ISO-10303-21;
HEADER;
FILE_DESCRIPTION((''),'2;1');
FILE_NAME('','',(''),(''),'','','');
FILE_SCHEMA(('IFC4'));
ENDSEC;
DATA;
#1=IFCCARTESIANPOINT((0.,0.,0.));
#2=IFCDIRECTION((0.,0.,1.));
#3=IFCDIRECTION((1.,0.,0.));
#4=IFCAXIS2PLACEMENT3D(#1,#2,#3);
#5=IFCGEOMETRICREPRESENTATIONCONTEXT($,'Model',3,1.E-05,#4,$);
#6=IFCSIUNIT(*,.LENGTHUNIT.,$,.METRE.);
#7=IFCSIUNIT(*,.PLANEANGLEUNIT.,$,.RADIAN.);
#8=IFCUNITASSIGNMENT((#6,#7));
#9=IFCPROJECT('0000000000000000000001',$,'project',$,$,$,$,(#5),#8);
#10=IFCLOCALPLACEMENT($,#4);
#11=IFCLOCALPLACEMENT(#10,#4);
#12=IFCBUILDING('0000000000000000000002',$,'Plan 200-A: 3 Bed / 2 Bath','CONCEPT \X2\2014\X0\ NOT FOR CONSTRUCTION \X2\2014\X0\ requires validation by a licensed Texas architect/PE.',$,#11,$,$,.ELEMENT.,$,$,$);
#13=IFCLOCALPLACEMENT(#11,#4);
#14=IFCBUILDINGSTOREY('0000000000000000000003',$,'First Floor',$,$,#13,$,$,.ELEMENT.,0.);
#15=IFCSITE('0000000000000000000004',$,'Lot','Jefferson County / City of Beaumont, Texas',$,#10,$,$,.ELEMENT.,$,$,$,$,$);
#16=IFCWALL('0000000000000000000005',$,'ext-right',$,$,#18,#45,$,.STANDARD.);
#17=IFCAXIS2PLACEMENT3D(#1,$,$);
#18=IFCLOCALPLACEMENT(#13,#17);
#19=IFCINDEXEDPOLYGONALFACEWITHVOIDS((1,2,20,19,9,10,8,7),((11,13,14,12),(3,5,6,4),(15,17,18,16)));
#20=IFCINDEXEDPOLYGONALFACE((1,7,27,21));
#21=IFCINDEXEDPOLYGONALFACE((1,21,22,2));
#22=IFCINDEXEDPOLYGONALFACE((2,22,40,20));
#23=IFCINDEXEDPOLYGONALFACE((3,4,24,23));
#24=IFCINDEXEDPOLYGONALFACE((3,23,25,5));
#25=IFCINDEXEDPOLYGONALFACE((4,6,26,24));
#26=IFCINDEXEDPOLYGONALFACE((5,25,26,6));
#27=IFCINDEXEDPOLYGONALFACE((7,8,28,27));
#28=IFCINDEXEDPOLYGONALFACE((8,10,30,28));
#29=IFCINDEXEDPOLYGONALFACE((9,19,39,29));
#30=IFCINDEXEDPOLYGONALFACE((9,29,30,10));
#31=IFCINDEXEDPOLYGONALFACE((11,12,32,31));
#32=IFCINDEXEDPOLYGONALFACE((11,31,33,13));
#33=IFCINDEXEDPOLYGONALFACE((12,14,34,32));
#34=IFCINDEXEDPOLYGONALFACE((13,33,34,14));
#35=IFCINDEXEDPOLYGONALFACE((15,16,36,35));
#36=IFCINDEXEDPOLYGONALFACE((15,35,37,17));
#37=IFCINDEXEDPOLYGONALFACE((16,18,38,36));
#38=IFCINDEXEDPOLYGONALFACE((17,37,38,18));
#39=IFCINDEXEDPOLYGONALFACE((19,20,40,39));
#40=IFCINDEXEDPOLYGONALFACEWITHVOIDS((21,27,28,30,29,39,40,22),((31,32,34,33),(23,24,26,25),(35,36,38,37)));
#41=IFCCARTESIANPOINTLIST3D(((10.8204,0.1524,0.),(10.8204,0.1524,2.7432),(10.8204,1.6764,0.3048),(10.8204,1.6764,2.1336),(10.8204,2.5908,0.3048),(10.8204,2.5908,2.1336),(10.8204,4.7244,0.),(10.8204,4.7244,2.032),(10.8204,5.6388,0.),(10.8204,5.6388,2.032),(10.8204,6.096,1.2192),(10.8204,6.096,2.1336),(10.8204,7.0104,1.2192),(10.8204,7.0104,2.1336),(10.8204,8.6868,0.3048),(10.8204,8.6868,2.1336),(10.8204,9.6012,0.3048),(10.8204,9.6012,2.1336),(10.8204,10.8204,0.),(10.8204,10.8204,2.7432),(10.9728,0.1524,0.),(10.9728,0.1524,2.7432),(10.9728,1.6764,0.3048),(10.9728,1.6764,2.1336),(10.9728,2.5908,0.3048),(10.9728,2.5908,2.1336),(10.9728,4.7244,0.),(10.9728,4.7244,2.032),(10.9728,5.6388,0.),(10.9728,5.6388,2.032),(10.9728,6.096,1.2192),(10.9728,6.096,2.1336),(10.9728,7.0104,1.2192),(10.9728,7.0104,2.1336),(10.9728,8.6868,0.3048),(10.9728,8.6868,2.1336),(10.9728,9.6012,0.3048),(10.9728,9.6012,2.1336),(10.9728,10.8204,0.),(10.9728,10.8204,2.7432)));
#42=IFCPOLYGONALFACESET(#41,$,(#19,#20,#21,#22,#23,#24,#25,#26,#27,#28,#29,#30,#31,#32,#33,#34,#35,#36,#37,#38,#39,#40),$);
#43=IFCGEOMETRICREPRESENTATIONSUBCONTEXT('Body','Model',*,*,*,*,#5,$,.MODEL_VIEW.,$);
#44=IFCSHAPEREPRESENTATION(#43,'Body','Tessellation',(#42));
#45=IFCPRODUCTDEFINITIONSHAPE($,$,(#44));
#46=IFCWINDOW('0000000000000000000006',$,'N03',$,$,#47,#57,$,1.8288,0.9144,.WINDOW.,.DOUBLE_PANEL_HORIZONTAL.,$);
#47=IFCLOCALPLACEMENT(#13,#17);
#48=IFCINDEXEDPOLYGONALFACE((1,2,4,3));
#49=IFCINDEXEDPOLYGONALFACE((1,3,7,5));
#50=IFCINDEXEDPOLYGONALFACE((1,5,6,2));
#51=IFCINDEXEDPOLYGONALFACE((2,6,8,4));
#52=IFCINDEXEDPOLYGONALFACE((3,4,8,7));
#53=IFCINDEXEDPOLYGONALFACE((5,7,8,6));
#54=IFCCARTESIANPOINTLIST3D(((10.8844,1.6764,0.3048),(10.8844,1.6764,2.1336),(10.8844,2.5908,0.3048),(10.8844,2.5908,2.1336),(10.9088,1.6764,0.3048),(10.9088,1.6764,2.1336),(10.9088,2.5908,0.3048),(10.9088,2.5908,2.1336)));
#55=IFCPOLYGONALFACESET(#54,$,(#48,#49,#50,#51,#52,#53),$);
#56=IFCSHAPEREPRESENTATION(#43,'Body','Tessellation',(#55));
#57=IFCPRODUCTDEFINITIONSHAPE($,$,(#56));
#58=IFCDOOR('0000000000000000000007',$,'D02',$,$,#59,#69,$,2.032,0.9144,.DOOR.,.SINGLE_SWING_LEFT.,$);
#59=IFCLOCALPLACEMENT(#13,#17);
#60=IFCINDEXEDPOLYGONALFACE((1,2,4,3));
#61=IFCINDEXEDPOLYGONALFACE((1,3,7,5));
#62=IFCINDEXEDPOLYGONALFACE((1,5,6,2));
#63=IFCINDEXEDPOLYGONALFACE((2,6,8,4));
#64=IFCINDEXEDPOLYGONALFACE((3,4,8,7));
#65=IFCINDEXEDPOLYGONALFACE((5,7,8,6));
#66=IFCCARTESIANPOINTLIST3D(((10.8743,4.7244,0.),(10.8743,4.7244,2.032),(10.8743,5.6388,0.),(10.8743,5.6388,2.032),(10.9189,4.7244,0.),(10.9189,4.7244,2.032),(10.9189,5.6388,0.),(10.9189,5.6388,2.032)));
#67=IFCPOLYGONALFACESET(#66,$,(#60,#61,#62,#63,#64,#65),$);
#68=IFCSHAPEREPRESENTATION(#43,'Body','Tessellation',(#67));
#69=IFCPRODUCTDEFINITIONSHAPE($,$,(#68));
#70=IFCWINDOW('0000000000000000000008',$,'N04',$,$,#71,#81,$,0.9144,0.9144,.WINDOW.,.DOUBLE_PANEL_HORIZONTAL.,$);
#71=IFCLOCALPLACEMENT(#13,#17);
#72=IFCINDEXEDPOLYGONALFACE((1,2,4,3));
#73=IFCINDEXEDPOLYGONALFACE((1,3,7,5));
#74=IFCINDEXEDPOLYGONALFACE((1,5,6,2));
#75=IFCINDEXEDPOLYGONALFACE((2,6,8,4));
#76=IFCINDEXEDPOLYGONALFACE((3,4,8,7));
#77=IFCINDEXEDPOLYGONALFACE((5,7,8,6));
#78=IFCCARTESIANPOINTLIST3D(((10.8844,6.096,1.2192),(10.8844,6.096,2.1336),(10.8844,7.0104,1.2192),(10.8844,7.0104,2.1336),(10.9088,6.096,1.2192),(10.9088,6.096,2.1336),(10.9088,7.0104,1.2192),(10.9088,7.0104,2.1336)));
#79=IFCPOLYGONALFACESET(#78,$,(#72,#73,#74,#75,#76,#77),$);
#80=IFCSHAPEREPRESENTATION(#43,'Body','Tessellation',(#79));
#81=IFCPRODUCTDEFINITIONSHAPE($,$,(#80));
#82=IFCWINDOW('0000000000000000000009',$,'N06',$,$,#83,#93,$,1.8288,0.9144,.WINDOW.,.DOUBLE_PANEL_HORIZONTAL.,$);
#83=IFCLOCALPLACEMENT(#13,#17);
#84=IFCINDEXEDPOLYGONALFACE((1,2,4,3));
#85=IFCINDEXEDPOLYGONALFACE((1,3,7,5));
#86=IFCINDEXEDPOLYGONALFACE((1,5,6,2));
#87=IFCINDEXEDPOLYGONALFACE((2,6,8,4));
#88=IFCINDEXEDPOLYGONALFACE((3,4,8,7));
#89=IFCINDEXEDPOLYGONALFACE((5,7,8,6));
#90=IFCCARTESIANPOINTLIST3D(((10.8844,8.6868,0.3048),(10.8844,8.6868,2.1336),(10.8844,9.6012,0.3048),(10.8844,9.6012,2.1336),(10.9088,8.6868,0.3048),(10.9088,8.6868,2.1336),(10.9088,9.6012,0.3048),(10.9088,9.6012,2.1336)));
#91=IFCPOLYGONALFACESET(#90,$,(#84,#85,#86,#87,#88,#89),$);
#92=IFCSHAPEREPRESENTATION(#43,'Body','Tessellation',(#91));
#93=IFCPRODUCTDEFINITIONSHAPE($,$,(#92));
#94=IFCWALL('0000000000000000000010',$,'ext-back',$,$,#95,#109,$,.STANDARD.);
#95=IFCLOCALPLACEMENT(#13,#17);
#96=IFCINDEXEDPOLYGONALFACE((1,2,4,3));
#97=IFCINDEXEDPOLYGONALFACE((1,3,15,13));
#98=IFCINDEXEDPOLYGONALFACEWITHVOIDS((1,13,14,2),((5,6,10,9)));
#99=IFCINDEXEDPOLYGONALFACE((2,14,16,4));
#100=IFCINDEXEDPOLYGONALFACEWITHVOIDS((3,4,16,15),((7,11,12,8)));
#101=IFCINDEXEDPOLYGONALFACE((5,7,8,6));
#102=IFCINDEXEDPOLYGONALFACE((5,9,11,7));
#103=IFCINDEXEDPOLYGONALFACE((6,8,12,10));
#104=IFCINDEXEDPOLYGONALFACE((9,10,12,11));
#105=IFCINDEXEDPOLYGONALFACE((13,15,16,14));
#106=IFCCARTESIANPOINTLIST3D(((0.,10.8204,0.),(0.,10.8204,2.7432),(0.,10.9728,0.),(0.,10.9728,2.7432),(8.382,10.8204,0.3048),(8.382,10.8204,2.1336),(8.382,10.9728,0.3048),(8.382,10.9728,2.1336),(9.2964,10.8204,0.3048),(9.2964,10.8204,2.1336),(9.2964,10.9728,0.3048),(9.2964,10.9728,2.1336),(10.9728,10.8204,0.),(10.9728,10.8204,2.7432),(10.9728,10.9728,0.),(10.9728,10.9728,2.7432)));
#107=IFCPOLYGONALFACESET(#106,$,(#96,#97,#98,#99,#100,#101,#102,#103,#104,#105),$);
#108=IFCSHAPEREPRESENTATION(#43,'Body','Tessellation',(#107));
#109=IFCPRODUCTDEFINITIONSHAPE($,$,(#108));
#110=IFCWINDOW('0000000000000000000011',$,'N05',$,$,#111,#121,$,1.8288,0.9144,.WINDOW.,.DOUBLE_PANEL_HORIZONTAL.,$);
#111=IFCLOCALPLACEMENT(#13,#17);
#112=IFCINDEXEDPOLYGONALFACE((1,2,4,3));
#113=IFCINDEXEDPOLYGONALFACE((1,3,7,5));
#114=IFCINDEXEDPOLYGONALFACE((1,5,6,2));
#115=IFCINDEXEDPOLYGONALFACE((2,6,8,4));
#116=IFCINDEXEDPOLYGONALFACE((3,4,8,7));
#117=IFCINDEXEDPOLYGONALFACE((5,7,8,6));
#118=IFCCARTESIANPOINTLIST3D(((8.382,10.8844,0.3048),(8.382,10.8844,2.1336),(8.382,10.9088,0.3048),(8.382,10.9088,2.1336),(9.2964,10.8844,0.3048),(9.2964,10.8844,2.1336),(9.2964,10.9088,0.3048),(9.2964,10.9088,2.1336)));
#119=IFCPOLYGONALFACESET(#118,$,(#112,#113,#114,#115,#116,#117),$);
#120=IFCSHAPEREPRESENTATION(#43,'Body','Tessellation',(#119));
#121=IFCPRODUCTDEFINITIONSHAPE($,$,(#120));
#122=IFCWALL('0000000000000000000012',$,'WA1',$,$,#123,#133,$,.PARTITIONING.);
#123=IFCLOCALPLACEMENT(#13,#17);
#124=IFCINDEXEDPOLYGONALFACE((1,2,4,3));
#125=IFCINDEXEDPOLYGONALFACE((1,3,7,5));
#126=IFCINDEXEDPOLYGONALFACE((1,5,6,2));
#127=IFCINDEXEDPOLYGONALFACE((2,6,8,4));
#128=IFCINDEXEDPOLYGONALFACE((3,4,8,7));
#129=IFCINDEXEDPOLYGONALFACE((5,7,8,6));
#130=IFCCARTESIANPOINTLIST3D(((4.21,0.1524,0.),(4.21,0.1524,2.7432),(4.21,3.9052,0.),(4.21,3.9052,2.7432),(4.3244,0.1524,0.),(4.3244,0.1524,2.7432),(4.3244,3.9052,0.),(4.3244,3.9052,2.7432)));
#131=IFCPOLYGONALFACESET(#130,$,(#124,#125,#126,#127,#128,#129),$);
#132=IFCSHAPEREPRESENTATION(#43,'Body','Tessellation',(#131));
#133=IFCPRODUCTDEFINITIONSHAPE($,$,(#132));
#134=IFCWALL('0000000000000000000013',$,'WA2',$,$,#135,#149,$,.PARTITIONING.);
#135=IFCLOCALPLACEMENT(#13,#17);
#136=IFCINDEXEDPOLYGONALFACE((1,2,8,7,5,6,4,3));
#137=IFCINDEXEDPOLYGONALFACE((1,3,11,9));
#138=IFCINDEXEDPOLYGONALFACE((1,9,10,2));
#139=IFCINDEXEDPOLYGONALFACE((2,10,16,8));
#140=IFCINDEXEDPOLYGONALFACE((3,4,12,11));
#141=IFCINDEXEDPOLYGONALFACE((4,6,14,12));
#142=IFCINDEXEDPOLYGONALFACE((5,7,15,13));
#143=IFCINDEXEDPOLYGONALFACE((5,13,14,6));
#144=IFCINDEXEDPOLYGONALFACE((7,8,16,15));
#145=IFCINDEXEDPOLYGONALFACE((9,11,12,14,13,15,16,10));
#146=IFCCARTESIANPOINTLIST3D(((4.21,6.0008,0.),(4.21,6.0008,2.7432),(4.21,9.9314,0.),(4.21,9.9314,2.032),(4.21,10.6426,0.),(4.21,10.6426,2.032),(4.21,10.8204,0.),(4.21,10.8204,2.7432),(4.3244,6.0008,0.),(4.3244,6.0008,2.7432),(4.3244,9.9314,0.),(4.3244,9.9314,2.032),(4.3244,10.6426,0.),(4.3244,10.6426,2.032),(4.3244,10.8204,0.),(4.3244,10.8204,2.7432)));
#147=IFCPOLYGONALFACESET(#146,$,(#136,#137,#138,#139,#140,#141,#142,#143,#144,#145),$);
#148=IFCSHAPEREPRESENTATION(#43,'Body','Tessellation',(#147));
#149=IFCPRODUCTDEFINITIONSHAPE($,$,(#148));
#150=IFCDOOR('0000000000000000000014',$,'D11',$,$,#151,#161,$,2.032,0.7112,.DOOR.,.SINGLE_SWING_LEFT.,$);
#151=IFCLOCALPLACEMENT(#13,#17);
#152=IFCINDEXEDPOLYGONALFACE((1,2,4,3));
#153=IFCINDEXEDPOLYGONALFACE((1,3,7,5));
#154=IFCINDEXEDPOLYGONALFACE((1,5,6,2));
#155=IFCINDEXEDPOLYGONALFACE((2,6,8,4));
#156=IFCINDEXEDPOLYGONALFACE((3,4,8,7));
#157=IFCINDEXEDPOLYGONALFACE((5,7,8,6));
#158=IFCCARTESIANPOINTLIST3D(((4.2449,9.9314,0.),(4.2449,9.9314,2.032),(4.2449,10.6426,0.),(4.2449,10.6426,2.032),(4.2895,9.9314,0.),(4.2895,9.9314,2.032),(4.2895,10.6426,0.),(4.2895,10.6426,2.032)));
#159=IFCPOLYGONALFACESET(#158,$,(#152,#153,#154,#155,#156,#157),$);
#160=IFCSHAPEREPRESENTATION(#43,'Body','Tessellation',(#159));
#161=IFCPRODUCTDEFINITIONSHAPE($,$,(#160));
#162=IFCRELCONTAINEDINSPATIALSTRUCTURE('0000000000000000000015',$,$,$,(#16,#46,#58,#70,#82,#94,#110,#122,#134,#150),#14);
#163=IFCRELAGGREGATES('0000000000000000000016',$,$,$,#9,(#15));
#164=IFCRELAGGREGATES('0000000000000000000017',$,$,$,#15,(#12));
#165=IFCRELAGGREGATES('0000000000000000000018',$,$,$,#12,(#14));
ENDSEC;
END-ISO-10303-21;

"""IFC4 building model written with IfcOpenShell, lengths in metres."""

from ifc_helpers import new_model, si_unit, frame, frame_2d, origin_with_axes, place, context, subcontext, project, spatial, rectangle, extrude, element, fill, save


model = new_model("IFC4")

# Units and contexts
model_context = context("Model", 3, precision=1e-05, world=origin_with_axes())
body_context = subcontext(model_context, "Body", "Model", "MODEL_VIEW")
ifc_project = project(units=[si_unit("LENGTHUNIT", "METRE"), si_unit("PLANEANGLEUNIT", "RADIAN")], contexts=[model_context])

# Site, building, storey
site_placement = place(None, origin_with_axes())
site = spatial("IfcSite", under=ifc_project, at=site_placement, Name="Lot", Description="Jefferson County / City of Beaumont, Texas", CompositionType="ELEMENT")
building_placement = place(site_placement, origin_with_axes())
building = spatial("IfcBuilding", under=site, at=building_placement, Name="Plan 200-A: 3 Bed / 2 Bath", Description="CONCEPT — NOT FOR CONSTRUCTION — requires validation by a licensed Texas architect/PE.", CompositionType="ELEMENT")
storey_placement = place(building_placement, origin_with_axes())
storey = spatial("IfcBuildingStorey", under=building, at=storey_placement, Name="First Floor", CompositionType="ELEMENT", Elevation=0.0)

# Wall, openings, windows, door
wall_1_placement = place(storey_placement, frame((10.8966, 0.1524, 0.0), z_axis=(0.0, 0.0, 1.0), x_axis=(0.0, 1.0, 0.0)))
wall_1 = element("IfcWall", 1, at=wall_1_placement, inside=storey, Name="ext-right", PredefinedType="STANDARD", context=body_context, shape_type="SweptSolid", body=[
    extrude(rectangle(XDim=10.668, YDim=0.1524, at=frame_2d((5.334, 0.0), x_axis=(1.0, 0.0))), origin_with_axes(), (0.0, 0.0, 1.0), 2.7432),
])
opening_1_placement = place(wall_1_placement, frame((1.524, 0.0, 0.3048), z_axis=(0.0, 0.0, 1.0), x_axis=(1.0, 0.0, 0.0)))
opening_1 = element("IfcOpeningElement", 2, at=opening_1_placement, cuts=wall_1, PredefinedType="OPENING", context=body_context, shape_type="SweptSolid", body=[
    extrude(rectangle(XDim=0.9144, YDim=0.1829, at=frame_2d((0.4572, 0.0), x_axis=(1.0, 0.0))), origin_with_axes(), (0.0, 0.0, 1.0), 1.8288),
])
opening_2_placement = place(wall_1_placement, frame((4.572, 0.0, 0.0), z_axis=(0.0, 0.0, 1.0), x_axis=(1.0, 0.0, 0.0)))
opening_2 = element("IfcOpeningElement", 3, at=opening_2_placement, cuts=wall_1, PredefinedType="OPENING", context=body_context, shape_type="SweptSolid", body=[
    extrude(rectangle(XDim=0.9144, YDim=0.1829, at=frame_2d((0.4572, 0.0), x_axis=(1.0, 0.0))), origin_with_axes(), (0.0, 0.0, 1.0), 2.032),
])
opening_3_placement = place(wall_1_placement, frame((5.9436, 0.0, 1.2192), z_axis=(0.0, 0.0, 1.0), x_axis=(1.0, 0.0, 0.0)))
opening_3 = element("IfcOpeningElement", 4, at=opening_3_placement, cuts=wall_1, PredefinedType="OPENING", context=body_context, shape_type="SweptSolid", body=[
    extrude(rectangle(XDim=0.9144, YDim=0.1829, at=frame_2d((0.4572, 0.0), x_axis=(1.0, 0.0))), origin_with_axes(), (0.0, 0.0, 1.0), 0.9144),
])
opening_4_placement = place(wall_1_placement, frame((8.5344, 0.0, 0.3048), z_axis=(0.0, 0.0, 1.0), x_axis=(1.0, 0.0, 0.0)))
opening_4 = element("IfcOpeningElement", 5, at=opening_4_placement, cuts=wall_1, PredefinedType="OPENING", context=body_context, shape_type="SweptSolid", body=[
    extrude(rectangle(XDim=0.9144, YDim=0.1829, at=frame_2d((0.4572, 0.0), x_axis=(1.0, 0.0))), origin_with_axes(), (0.0, 0.0, 1.0), 1.8288),
])
window_1_placement = place(opening_1_placement, origin_with_axes())
window_1 = element("IfcWindow", 6, at=window_1_placement, inside=storey, Name="N03", OverallHeight=1.8288, OverallWidth=0.9144, PartitioningType="DOUBLE_PANEL_HORIZONTAL", PredefinedType="WINDOW", context=body_context, shape_type="SweptSolid", body=[
    extrude(rectangle(XDim=0.9144, YDim=0.0244, at=frame_2d((0.4572, 0.0), x_axis=(1.0, 0.0))), origin_with_axes(), (0.0, 0.0, 1.0), 1.8288),
])
fill(opening_1, window_1)
door_1_placement = place(opening_2_placement, origin_with_axes())
door_1 = element("IfcDoor", 7, at=door_1_placement, inside=storey, Name="D02", OperationType="SINGLE_SWING_LEFT", OverallHeight=2.032, OverallWidth=0.9144, PredefinedType="DOOR", context=body_context, shape_type="SweptSolid", body=[
    extrude(rectangle(XDim=0.9144, YDim=0.0445, at=frame_2d((0.4572, 0.0), x_axis=(1.0, 0.0))), origin_with_axes(), (0.0, 0.0, 1.0), 2.032),
])
fill(opening_2, door_1)
window_2_placement = place(opening_3_placement, origin_with_axes())
window_2 = element("IfcWindow", 8, at=window_2_placement, inside=storey, Name="N04", OverallHeight=0.9144, OverallWidth=0.9144, PartitioningType="DOUBLE_PANEL_HORIZONTAL", PredefinedType="WINDOW", context=body_context, shape_type="SweptSolid", body=[
    extrude(rectangle(XDim=0.9144, YDim=0.0244, at=frame_2d((0.4572, 0.0), x_axis=(1.0, 0.0))), origin_with_axes(), (0.0, 0.0, 1.0), 0.9144),
])
fill(opening_3, window_2)
window_3_placement = place(opening_4_placement, origin_with_axes())
window_3 = element("IfcWindow", 9, at=window_3_placement, inside=storey, Name="N06", OverallHeight=1.8288, OverallWidth=0.9144, PartitioningType="DOUBLE_PANEL_HORIZONTAL", PredefinedType="WINDOW", context=body_context, shape_type="SweptSolid", body=[
    extrude(rectangle(XDim=0.9144, YDim=0.0244, at=frame_2d((0.4572, 0.0), x_axis=(1.0, 0.0))), origin_with_axes(), (0.0, 0.0, 1.0), 1.8288),
])
fill(opening_4, window_3)

# Wall, opening, window
wall_2_placement = place(storey_placement, frame((10.9728, 10.8966, 0.0), z_axis=(0.0, 0.0, 1.0), x_axis=(-1.0, 0.0, 0.0)))
wall_2 = element("IfcWall", 10, at=wall_2_placement, inside=storey, Name="ext-back", PredefinedType="STANDARD", context=body_context, shape_type="SweptSolid", body=[
    extrude(rectangle(XDim=10.9728, YDim=0.1524, at=frame_2d((5.4864, 0.0), x_axis=(1.0, 0.0))), origin_with_axes(), (0.0, 0.0, 1.0), 2.7432),
])
opening_5_placement = place(wall_2_placement, frame((1.6764, 0.0, 0.3048), z_axis=(0.0, 0.0, 1.0), x_axis=(1.0, 0.0, 0.0)))
opening_5 = element("IfcOpeningElement", 11, at=opening_5_placement, cuts=wall_2, PredefinedType="OPENING", context=body_context, shape_type="SweptSolid", body=[
    extrude(rectangle(XDim=0.9144, YDim=0.1829, at=frame_2d((0.4572, 0.0), x_axis=(1.0, 0.0))), origin_with_axes(), (0.0, 0.0, 1.0), 1.8288),
])
window_4_placement = place(opening_5_placement, origin_with_axes())
window_4 = element("IfcWindow", 12, at=window_4_placement, inside=storey, Name="N05", OverallHeight=1.8288, OverallWidth=0.9144, PartitioningType="DOUBLE_PANEL_HORIZONTAL", PredefinedType="WINDOW", context=body_context, shape_type="SweptSolid", body=[
    extrude(rectangle(XDim=0.9144, YDim=0.0244, at=frame_2d((0.4572, 0.0), x_axis=(1.0, 0.0))), origin_with_axes(), (0.0, 0.0, 1.0), 1.8288),
])
fill(opening_5, window_4)

# Wall
wall_3_placement = place(storey_placement, frame((4.2672, 0.1524, 0.0), z_axis=(0.0, 0.0, 1.0), x_axis=(0.0, 1.0, 0.0)))
element("IfcWall", 13, at=wall_3_placement, inside=storey, Name="WA1", PredefinedType="PARTITIONING", context=body_context, shape_type="SweptSolid", body=[
    extrude(rectangle(XDim=3.7529, YDim=0.1143, at=frame_2d((1.8764, 0.0), x_axis=(1.0, 0.0))), origin_with_axes(), (0.0, 0.0, 1.0), 2.7432),
])

# Wall, opening, door
wall_4_placement = place(storey_placement, frame((4.2672, 6.0008, 0.0), z_axis=(0.0, 0.0, 1.0), x_axis=(0.0, 1.0, 0.0)))
wall_4 = element("IfcWall", 14, at=wall_4_placement, inside=storey, Name="WA2", PredefinedType="PARTITIONING", context=body_context, shape_type="SweptSolid", body=[
    extrude(rectangle(XDim=4.8197, YDim=0.1143, at=frame_2d((2.4098, 0.0), x_axis=(1.0, 0.0))), origin_with_axes(), (0.0, 0.0, 1.0), 2.7432),
])
opening_6_placement = place(wall_4_placement, frame((3.9307, 0.0, 0.0), z_axis=(0.0, 0.0, 1.0), x_axis=(1.0, 0.0, 0.0)))
opening_6 = element("IfcOpeningElement", 15, at=opening_6_placement, cuts=wall_4, PredefinedType="OPENING", context=body_context, shape_type="SweptSolid", body=[
    extrude(rectangle(XDim=0.7112, YDim=0.1448, at=frame_2d((0.3556, 0.0), x_axis=(1.0, 0.0))), origin_with_axes(), (0.0, 0.0, 1.0), 2.032),
])
door_2_placement = place(opening_6_placement, origin_with_axes())
door_2 = element("IfcDoor", 16, at=door_2_placement, inside=storey, Name="D11", OperationType="SINGLE_SWING_LEFT", OverallHeight=2.032, OverallWidth=0.7112, PredefinedType="DOOR", context=body_context, shape_type="SweptSolid", body=[
    extrude(rectangle(XDim=0.7112, YDim=0.0445, at=frame_2d((0.3556, 0.0), x_axis=(1.0, 0.0))), origin_with_axes(), (0.0, 0.0, 1.0), 2.032),
])
fill(opening_6, door_2)

save(model, "model.ifc")
